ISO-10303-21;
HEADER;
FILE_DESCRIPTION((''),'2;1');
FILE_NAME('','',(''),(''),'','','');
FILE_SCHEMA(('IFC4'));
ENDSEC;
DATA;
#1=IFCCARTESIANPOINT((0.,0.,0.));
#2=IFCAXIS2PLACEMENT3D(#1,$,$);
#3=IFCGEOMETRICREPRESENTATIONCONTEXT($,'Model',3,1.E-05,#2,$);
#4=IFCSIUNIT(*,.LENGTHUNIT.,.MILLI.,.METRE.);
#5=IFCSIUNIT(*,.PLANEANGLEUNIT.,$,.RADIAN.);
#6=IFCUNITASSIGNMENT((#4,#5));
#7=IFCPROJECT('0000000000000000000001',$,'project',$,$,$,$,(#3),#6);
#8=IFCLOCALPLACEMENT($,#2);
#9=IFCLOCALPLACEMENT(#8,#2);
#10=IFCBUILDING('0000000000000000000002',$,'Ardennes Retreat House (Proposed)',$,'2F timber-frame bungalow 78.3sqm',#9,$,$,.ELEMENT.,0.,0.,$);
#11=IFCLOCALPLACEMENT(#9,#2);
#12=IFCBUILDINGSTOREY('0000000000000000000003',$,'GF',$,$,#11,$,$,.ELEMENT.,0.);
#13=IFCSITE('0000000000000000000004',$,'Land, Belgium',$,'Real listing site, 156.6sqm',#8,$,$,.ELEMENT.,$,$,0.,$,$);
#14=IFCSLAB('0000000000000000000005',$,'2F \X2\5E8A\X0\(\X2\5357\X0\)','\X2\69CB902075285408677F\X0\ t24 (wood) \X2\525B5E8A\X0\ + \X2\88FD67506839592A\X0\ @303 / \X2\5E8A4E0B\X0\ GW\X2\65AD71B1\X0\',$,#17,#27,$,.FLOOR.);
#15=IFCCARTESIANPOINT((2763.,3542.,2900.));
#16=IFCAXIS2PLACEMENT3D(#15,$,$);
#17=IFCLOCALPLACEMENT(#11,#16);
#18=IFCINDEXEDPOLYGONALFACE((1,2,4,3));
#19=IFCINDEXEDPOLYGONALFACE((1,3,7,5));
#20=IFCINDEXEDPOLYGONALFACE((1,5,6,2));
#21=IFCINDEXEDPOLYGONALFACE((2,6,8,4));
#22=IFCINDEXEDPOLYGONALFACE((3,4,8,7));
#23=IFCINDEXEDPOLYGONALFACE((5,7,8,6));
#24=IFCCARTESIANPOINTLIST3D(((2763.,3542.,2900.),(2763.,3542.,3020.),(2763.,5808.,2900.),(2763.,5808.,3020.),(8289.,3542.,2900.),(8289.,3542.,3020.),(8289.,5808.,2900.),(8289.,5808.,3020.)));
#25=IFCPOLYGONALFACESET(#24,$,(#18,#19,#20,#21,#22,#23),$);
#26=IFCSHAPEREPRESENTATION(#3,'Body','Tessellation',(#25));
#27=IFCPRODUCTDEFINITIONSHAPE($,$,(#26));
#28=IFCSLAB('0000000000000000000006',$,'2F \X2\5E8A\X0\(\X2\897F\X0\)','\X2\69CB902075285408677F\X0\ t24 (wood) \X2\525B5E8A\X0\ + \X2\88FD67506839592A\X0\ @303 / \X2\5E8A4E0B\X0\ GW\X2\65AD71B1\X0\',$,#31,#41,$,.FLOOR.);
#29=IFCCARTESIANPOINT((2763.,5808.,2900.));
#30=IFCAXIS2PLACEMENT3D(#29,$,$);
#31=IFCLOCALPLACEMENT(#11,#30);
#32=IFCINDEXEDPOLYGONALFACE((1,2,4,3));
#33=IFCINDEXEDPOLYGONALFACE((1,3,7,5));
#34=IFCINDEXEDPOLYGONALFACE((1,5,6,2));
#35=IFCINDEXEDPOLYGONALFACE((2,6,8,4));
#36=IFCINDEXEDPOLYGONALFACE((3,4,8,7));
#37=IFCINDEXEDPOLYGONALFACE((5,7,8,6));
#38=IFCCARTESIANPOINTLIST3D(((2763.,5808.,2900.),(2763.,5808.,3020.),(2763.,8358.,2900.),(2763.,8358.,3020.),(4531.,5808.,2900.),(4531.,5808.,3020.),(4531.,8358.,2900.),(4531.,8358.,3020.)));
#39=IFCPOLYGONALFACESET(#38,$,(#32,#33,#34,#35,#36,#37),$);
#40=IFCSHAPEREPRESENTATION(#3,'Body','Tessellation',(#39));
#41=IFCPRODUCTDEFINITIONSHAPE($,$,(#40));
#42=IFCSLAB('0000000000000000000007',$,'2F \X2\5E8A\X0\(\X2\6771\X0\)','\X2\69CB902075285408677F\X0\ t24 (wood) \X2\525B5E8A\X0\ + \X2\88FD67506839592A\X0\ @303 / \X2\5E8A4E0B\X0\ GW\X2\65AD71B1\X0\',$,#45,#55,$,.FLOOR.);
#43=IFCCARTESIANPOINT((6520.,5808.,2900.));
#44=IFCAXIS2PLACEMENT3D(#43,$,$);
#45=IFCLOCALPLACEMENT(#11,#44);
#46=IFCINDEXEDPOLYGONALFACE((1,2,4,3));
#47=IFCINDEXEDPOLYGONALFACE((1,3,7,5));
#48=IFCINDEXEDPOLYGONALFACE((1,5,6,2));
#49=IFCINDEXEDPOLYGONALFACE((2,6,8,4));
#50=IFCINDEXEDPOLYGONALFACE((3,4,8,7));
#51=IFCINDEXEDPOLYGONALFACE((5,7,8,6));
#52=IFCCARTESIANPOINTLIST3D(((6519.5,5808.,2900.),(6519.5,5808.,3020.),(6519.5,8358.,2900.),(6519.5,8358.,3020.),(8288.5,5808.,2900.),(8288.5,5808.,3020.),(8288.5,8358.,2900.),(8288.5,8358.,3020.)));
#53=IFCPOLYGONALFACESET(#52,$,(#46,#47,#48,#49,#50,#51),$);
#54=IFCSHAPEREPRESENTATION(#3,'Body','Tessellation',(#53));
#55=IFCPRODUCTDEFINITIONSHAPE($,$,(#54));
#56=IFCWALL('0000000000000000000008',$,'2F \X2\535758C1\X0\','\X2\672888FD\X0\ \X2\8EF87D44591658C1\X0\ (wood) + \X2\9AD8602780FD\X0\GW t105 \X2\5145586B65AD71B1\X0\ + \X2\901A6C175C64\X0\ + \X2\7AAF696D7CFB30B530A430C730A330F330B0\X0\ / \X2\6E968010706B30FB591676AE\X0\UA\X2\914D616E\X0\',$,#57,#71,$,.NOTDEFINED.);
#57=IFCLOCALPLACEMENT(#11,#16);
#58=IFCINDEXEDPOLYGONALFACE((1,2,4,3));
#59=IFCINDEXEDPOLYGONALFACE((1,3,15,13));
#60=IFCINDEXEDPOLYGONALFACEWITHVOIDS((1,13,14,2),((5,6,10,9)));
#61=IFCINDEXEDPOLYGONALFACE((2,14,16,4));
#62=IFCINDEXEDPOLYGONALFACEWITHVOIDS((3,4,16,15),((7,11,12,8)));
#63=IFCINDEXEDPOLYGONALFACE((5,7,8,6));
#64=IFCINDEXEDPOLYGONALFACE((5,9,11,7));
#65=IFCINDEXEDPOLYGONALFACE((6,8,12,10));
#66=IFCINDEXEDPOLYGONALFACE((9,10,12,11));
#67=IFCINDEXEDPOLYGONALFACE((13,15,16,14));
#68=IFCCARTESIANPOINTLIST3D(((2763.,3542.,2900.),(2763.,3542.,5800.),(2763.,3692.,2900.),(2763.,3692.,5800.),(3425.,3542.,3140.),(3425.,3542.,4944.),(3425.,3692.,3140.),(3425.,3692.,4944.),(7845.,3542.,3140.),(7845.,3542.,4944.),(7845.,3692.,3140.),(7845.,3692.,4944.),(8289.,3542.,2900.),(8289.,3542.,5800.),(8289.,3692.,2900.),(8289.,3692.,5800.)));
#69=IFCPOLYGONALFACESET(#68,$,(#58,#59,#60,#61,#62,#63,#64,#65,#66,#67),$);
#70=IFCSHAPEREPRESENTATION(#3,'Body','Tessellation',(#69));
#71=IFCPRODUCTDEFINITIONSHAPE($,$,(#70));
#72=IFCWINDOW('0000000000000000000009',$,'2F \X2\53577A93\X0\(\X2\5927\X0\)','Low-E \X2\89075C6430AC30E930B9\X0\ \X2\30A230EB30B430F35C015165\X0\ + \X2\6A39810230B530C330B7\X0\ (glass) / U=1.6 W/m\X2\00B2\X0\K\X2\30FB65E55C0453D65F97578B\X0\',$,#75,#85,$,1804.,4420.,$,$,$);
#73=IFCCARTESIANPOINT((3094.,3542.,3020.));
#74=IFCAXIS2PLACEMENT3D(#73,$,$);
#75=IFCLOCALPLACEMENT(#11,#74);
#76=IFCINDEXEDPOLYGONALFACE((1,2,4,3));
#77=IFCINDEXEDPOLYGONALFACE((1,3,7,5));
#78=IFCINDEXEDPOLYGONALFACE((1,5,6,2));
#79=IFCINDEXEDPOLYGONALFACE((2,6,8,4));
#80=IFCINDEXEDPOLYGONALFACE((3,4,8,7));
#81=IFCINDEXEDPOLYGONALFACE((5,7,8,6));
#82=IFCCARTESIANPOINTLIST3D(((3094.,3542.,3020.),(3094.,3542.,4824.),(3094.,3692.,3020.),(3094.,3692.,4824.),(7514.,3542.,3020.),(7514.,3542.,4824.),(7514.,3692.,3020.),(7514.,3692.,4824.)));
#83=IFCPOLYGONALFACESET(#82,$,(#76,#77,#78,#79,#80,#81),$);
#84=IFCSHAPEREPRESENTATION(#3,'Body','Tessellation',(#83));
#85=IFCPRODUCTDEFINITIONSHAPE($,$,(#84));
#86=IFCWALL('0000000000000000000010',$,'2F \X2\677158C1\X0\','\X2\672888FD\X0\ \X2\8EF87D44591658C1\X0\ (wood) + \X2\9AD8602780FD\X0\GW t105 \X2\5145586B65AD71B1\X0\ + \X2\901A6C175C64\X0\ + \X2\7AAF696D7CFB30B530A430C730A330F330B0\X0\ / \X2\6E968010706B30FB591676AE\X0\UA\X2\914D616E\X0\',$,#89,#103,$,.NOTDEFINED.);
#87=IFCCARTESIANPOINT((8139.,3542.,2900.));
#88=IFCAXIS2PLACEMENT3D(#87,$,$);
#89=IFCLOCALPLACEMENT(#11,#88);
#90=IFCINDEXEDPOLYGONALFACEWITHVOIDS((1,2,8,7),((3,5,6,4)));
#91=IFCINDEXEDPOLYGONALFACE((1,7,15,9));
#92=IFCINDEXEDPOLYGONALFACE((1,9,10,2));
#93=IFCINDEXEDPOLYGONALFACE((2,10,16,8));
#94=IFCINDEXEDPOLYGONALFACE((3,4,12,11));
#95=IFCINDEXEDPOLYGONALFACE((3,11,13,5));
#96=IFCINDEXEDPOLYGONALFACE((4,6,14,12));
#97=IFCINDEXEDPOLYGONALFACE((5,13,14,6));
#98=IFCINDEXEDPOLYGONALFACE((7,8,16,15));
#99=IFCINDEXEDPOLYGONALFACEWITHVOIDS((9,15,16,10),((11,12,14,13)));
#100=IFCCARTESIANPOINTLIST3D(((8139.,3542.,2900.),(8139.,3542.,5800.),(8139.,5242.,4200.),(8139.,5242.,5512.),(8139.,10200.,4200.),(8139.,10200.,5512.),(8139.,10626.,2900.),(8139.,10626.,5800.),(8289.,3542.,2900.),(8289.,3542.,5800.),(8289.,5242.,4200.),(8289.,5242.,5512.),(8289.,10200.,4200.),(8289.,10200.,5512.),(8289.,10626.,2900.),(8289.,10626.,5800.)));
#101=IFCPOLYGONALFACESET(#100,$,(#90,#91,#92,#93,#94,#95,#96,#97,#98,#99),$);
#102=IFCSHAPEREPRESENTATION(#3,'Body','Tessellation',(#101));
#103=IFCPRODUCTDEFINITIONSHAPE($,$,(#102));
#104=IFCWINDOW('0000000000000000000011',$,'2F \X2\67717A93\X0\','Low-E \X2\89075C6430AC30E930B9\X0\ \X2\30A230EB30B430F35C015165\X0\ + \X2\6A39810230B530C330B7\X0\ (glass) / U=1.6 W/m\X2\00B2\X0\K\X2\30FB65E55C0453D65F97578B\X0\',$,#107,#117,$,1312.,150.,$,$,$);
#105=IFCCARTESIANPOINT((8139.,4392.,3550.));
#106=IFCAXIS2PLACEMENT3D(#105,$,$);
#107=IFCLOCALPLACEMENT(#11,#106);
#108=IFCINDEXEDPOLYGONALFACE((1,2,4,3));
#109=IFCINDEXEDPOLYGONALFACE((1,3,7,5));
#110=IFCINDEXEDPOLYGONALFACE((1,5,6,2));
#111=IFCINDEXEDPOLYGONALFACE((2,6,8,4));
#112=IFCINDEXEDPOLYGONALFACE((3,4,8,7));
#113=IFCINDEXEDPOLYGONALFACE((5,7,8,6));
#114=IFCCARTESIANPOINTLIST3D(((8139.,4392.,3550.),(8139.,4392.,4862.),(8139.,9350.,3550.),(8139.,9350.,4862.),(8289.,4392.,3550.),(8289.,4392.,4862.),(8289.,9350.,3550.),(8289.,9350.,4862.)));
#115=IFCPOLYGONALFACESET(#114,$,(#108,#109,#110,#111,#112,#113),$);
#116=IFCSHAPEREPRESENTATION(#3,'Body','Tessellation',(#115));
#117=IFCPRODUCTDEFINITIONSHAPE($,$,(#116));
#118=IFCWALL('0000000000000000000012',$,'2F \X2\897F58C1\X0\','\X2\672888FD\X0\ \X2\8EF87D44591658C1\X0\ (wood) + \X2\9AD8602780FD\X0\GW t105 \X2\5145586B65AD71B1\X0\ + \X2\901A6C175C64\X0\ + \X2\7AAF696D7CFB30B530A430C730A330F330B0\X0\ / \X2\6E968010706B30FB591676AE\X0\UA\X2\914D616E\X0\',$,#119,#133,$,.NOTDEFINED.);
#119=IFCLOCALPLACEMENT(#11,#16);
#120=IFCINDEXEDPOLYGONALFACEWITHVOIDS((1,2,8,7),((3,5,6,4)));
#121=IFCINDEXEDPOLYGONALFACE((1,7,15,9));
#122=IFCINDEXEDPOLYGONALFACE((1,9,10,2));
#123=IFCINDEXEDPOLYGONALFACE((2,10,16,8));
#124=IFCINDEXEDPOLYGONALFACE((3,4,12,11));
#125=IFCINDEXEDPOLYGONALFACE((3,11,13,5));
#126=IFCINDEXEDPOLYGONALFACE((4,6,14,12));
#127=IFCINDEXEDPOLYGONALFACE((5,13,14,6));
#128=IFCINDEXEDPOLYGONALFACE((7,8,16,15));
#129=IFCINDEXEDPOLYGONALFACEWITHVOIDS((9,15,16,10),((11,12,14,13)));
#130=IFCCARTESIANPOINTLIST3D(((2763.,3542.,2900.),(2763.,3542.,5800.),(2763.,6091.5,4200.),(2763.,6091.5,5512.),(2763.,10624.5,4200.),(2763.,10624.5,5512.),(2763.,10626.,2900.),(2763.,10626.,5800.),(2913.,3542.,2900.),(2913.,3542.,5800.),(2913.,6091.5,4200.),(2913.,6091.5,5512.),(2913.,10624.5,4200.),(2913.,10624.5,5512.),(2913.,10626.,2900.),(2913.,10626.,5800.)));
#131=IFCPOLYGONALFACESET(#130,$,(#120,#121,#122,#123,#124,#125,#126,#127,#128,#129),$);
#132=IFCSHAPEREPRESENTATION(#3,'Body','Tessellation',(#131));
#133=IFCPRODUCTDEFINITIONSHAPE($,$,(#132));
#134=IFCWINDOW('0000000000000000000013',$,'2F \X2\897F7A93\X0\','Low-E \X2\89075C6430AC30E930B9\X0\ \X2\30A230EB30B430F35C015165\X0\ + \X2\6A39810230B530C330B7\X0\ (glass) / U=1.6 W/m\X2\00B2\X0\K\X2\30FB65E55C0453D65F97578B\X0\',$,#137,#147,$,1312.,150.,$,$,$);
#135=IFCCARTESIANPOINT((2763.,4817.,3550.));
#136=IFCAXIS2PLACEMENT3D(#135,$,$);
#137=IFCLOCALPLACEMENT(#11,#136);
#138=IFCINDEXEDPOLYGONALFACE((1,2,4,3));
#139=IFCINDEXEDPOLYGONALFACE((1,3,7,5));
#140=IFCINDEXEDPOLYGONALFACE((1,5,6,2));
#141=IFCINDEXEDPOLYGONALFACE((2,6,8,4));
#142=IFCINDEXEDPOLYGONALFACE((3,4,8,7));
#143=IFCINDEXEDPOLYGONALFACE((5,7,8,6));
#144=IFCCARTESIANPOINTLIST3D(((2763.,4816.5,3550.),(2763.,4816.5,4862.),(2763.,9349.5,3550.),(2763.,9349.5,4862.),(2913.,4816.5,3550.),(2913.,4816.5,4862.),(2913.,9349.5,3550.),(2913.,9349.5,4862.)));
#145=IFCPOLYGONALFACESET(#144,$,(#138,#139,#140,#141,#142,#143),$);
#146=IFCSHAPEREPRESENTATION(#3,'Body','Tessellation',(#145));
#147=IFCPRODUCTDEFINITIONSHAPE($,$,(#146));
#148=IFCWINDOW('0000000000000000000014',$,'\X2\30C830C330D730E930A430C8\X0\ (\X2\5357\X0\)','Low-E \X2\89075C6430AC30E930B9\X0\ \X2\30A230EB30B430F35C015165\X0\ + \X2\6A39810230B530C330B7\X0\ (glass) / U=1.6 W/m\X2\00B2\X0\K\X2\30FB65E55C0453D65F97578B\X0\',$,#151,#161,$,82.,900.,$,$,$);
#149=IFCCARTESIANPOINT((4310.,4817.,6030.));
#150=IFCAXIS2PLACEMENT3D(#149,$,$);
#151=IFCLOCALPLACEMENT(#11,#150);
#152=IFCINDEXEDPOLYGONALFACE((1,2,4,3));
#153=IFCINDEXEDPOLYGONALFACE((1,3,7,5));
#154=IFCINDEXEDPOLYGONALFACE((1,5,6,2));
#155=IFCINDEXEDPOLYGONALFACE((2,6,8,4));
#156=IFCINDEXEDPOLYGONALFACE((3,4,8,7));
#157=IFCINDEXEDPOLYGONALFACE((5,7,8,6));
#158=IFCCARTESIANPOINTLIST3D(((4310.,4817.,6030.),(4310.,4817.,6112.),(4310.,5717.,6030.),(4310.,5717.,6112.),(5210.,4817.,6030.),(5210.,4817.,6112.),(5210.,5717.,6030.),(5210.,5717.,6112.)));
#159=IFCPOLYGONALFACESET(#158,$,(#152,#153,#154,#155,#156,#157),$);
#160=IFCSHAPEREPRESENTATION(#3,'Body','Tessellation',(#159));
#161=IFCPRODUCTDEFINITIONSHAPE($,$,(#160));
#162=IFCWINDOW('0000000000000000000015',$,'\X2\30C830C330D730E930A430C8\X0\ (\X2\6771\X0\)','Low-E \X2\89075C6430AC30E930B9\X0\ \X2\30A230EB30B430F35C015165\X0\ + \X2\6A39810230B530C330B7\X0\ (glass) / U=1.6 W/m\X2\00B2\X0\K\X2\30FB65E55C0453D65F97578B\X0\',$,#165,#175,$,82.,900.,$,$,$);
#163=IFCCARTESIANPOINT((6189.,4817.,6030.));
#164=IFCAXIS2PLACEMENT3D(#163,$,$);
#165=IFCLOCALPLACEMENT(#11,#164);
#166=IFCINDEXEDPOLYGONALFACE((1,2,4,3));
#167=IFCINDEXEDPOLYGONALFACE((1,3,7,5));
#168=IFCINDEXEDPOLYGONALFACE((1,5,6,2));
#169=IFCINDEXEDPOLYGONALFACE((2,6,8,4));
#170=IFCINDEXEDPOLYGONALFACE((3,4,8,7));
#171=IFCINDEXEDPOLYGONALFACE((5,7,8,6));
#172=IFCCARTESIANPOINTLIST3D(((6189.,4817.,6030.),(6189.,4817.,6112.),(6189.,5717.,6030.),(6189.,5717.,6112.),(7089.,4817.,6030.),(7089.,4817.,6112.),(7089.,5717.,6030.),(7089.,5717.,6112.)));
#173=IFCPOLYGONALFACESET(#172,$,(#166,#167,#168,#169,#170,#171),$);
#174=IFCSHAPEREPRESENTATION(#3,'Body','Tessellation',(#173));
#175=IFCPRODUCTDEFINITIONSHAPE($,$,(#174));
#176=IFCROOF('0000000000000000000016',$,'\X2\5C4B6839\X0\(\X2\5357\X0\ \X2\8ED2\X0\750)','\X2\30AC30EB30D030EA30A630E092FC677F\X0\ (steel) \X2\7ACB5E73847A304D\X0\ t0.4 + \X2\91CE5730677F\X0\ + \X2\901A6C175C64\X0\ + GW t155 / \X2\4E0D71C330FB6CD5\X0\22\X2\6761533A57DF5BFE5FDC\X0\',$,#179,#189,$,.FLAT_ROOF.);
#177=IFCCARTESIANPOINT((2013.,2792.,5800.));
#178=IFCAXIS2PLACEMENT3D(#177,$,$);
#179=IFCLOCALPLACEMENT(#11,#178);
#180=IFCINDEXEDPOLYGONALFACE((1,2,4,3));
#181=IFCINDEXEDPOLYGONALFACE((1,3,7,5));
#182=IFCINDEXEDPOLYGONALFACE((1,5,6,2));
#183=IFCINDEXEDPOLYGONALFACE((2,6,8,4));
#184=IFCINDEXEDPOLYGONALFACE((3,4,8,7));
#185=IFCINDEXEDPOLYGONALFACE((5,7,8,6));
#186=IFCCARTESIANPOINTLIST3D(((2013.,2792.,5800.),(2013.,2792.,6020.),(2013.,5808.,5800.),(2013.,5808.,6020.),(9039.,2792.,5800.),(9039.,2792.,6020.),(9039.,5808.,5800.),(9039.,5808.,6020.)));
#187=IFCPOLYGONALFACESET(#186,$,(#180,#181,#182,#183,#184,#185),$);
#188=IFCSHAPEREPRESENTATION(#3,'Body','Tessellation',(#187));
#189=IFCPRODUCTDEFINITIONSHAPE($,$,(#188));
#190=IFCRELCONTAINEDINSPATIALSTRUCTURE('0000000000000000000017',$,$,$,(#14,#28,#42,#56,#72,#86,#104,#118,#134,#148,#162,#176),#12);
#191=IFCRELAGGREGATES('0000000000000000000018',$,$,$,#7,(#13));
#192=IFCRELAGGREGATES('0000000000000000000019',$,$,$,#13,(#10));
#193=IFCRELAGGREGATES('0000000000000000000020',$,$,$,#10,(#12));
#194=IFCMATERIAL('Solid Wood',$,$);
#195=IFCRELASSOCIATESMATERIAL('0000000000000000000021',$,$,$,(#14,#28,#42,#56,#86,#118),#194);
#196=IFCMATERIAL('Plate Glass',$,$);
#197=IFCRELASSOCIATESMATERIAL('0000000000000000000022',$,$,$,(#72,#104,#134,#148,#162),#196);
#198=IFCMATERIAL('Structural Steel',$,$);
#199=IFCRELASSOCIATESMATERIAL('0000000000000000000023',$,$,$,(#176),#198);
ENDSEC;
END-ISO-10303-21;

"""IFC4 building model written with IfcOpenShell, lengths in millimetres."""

from ifc_helpers import new_model, si_unit, frame, frame_2d, origin, place, context, project, spatial, rectangle, extrude, material, element, fill, save


model = new_model("IFC4")

# Units and contexts
model_context = context("Model", 3, precision=1e-05, world=origin())
ifc_project = project(units=[si_unit("LENGTHUNIT", "METRE", prefix="MILLI"), si_unit("PLANEANGLEUNIT", "RADIAN")], contexts=[model_context])

# Site, building, storey
site_placement = place(None, origin())
site = spatial("IfcSite", under=ifc_project, at=site_placement, Name="Land, Belgium", ObjectType="Real listing site, 156.6sqm", CompositionType="ELEMENT", RefElevation=0.0)
building_placement = place(site_placement, origin())
building = spatial("IfcBuilding", under=site, at=building_placement, Name="Ardennes Retreat House (Proposed)", ObjectType="2F timber-frame bungalow 78.3sqm", CompositionType="ELEMENT", ElevationOfRefHeight=0.0, ElevationOfTerrain=0.0)
storey_placement = place(building_placement, origin())
storey = spatial("IfcBuildingStorey", under=building, at=storey_placement, Name="GF", CompositionType="ELEMENT", Elevation=0.0)

# Slabs
ifc_material_1 = material(Name="Solid Wood")
slab_1_placement = place(storey_placement, frame((2763.0, 3542.0, 2900.0)))
element("IfcSlab", 1, at=slab_1_placement, inside=storey, material=ifc_material_1, Name="2F 床(南)", Description="構造用合板 t24 (wood) 剛床 + 製材根太 @303 / 床下 GW断熱", PredefinedType="FLOOR", context=model_context, shape_type="SweptSolid", body=[
    extrude(rectangle(XDim=5526.0, YDim=2266.0, at=frame_2d((2763.0, 1133.0))), frame((2763.0, 3542.0, 2900.0)), (0.0, 0.0, 1.0), 120.0),
])
slab_2_placement = place(storey_placement, frame((2763.0, 5808.0, 2900.0)))
element("IfcSlab", 2, at=slab_2_placement, inside=storey, material=ifc_material_1, Name="2F 床(西)", Description="構造用合板 t24 (wood) 剛床 + 製材根太 @303 / 床下 GW断熱", PredefinedType="FLOOR", context=model_context, shape_type="SweptSolid", body=[
    extrude(rectangle(XDim=1768.0, YDim=2550.0, at=frame_2d((884.0, 1275.0))), frame((2763.0, 5808.0, 2900.0)), (0.0, 0.0, 1.0), 120.0),
])
slab_3_placement = place(storey_placement, frame((6520.0, 5808.0, 2900.0)))
element("IfcSlab", 3, at=slab_3_placement, inside=storey, material=ifc_material_1, Name="2F 床(東)", Description="構造用合板 t24 (wood) 剛床 + 製材根太 @303 / 床下 GW断熱", PredefinedType="FLOOR", context=model_context, shape_type="SweptSolid", body=[
    extrude(rectangle(XDim=1769.0, YDim=2550.0, at=frame_2d((884.0, 1275.0))), frame((6520.0, 5808.0, 2900.0)), (0.0, 0.0, 1.0), 120.0),
])

# Walls, openings, windows
wall_1_placement = place(storey_placement, frame((2763.0, 3542.0, 2900.0)))
wall_1 = element("IfcWall", 4, at=wall_1_placement, inside=storey, material=ifc_material_1, Name="2F 南壁", Description="木製 軸組外壁 (wood) + 高性能GW t105 充填断熱 + 通気層 + 窯業系サイディング / 準耐火・外皮UA配慮", PredefinedType="NOTDEFINED", context=model_context, shape_type="SweptSolid", body=[
    extrude(rectangle(XDim=5526.0, YDim=150.0, at=frame_2d((2763.0, 75.0))), frame((2763.0, 3542.0, 2900.0)), (0.0, 0.0, 1.0), 2900.0),
])
opening_1_placement = place(storey_placement, frame((3094.0, 3542.0, 3020.0)))
opening_1 = element("IfcOpeningElement", 5, at=opening_1_placement, cuts=wall_1, PredefinedType="NOTDEFINED", context=model_context, shape_type="SweptSolid", body=[
    extrude(rectangle(XDim=4420.0, YDim=150.0, at=frame_2d((2210.0, 75.0))), frame((3094.0, 3542.0, 3020.0)), (0.0, 0.0, 1.0), 1804.0),
])
ifc_material_2 = material(Name="Plate Glass")
window_1_placement = place(storey_placement, frame((3094.0, 3542.0, 3020.0)))
window_1 = element("IfcWindow", 6, at=window_1_placement, inside=storey, material=ifc_material_2, Name="2F 南窓(大)", Description="Low-E 複層ガラス アルゴン封入 + 樹脂サッシ (glass) / U=1.6 W/m²K・日射取得型", OverallHeight=1804.0, OverallWidth=4420.0, context=model_context, shape_type="SweptSolid", body=[
    extrude(rectangle(XDim=4420.0, YDim=150.0, at=frame_2d((2210.0, 75.0))), frame((3094.0, 3542.0, 3020.0)), (0.0, 0.0, 1.0), 1804.0),
])
fill(opening_1, window_1)
wall_2_placement = place(storey_placement, frame((8139.0, 3542.0, 2900.0)))
wall_2 = element("IfcWall", 7, at=wall_2_placement, inside=storey, material=ifc_material_1, Name="2F 東壁", Description="木製 軸組外壁 (wood) + 高性能GW t105 充填断熱 + 通気層 + 窯業系サイディング / 準耐火・外皮UA配慮", PredefinedType="NOTDEFINED", context=model_context, shape_type="SweptSolid", body=[
    extrude(rectangle(XDim=150.0, YDim=7084.0, at=frame_2d((75.0, 3542.0))), frame((8139.0, 3542.0, 2900.0)), (0.0, 0.0, 1.0), 2900.0),
])
opening_2_placement = place(storey_placement, frame((8139.0, 4392.0, 3550.0)))
opening_2 = element("IfcOpeningElement", 8, at=opening_2_placement, cuts=wall_2, PredefinedType="NOTDEFINED", context=model_context, shape_type="SweptSolid", body=[
    extrude(rectangle(XDim=150.0, YDim=4958.0, at=frame_2d((75.0, 2479.0))), frame((8139.0, 4392.0, 3550.0)), (0.0, 0.0, 1.0), 1312.0),
])
window_2_placement = place(storey_placement, frame((8139.0, 4392.0, 3550.0)))
window_2 = element("IfcWindow", 9, at=window_2_placement, inside=storey, material=ifc_material_2, Name="2F 東窓", Description="Low-E 複層ガラス アルゴン封入 + 樹脂サッシ (glass) / U=1.6 W/m²K・日射取得型", OverallHeight=1312.0, OverallWidth=150.0, context=model_context, shape_type="SweptSolid", body=[
    extrude(rectangle(XDim=150.0, YDim=4958.0, at=frame_2d((75.0, 2479.0))), frame((8139.0, 4392.0, 3550.0)), (0.0, 0.0, 1.0), 1312.0),
])
fill(opening_2, window_2)
wall_3_placement = place(storey_placement, frame((2763.0, 3542.0, 2900.0)))
wall_3 = element("IfcWall", 10, at=wall_3_placement, inside=storey, material=ifc_material_1, Name="2F 西壁", Description="木製 軸組外壁 (wood) + 高性能GW t105 充填断熱 + 通気層 + 窯業系サイディング / 準耐火・外皮UA配慮", PredefinedType="NOTDEFINED", context=model_context, shape_type="SweptSolid", body=[
    extrude(rectangle(XDim=150.0, YDim=7084.0, at=frame_2d((75.0, 3542.0))), frame((2763.0, 3542.0, 2900.0)), (0.0, 0.0, 1.0), 2900.0),
])
opening_3_placement = place(storey_placement, frame((2763.0, 4817.0, 3550.0)))
opening_3 = element("IfcOpeningElement", 11, at=opening_3_placement, cuts=wall_3, PredefinedType="NOTDEFINED", context=model_context, shape_type="SweptSolid", body=[
    extrude(rectangle(XDim=150.0, YDim=4533.0, at=frame_2d((75.0, 2266.0))), frame((2763.0, 4817.0, 3550.0)), (0.0, 0.0, 1.0), 1312.0),
])
window_3_placement = place(storey_placement, frame((2763.0, 4817.0, 3550.0)))
window_3 = element("IfcWindow", 12, at=window_3_placement, inside=storey, material=ifc_material_2, Name="2F 西窓", Description="Low-E 複層ガラス アルゴン封入 + 樹脂サッシ (glass) / U=1.6 W/m²K・日射取得型", OverallHeight=1312.0, OverallWidth=150.0, context=model_context, shape_type="SweptSolid", body=[
    extrude(rectangle(XDim=150.0, YDim=4533.0, at=frame_2d((75.0, 2266.0))), frame((2763.0, 4817.0, 3550.0)), (0.0, 0.0, 1.0), 1312.0),
])
fill(opening_3, window_3)

# Windows
window_4_placement = place(storey_placement, frame((4310.0, 4817.0, 6030.0)))
element("IfcWindow", 13, at=window_4_placement, inside=storey, material=ifc_material_2, Name="トップライト (南)", Description="Low-E 複層ガラス アルゴン封入 + 樹脂サッシ (glass) / U=1.6 W/m²K・日射取得型", OverallHeight=82.0, OverallWidth=900.0, context=model_context, shape_type="SweptSolid", body=[
    extrude(rectangle(XDim=900.0, YDim=900.0, at=frame_2d((450.0, 450.0))), frame((4310.0, 4817.0, 6030.0)), (0.0, 0.0, 1.0), 82.0),
])
window_5_placement = place(storey_placement, frame((6189.0, 4817.0, 6030.0)))
element("IfcWindow", 14, at=window_5_placement, inside=storey, material=ifc_material_2, Name="トップライト (東)", Description="Low-E 複層ガラス アルゴン封入 + 樹脂サッシ (glass) / U=1.6 W/m²K・日射取得型", OverallHeight=82.0, OverallWidth=900.0, context=model_context, shape_type="SweptSolid", body=[
    extrude(rectangle(XDim=900.0, YDim=900.0, at=frame_2d((450.0, 450.0))), frame((6189.0, 4817.0, 6030.0)), (0.0, 0.0, 1.0), 82.0),
])

# Roof
ifc_material_3 = material(Name="Structural Steel")
roof_1_placement = place(storey_placement, frame((2013.0, 2792.0, 5800.0)))
element("IfcRoof", 15, at=roof_1_placement, inside=storey, material=ifc_material_3, Name="屋根(南 軒750)", Description="ガルバリウム鋼板 (steel) 立平葺き t0.4 + 野地板 + 通気層 + GW t155 / 不燃・法22条区域対応", PredefinedType="FLAT_ROOF", context=model_context, shape_type="SweptSolid", body=[
    extrude(rectangle(XDim=7026.0, YDim=3016.0, at=frame_2d((3513.0, 1508.0))), frame((2013.0, 2792.0, 5800.0)), (0.0, 0.0, 1.0), 220.0),
])

save(model, "model.ifc")
